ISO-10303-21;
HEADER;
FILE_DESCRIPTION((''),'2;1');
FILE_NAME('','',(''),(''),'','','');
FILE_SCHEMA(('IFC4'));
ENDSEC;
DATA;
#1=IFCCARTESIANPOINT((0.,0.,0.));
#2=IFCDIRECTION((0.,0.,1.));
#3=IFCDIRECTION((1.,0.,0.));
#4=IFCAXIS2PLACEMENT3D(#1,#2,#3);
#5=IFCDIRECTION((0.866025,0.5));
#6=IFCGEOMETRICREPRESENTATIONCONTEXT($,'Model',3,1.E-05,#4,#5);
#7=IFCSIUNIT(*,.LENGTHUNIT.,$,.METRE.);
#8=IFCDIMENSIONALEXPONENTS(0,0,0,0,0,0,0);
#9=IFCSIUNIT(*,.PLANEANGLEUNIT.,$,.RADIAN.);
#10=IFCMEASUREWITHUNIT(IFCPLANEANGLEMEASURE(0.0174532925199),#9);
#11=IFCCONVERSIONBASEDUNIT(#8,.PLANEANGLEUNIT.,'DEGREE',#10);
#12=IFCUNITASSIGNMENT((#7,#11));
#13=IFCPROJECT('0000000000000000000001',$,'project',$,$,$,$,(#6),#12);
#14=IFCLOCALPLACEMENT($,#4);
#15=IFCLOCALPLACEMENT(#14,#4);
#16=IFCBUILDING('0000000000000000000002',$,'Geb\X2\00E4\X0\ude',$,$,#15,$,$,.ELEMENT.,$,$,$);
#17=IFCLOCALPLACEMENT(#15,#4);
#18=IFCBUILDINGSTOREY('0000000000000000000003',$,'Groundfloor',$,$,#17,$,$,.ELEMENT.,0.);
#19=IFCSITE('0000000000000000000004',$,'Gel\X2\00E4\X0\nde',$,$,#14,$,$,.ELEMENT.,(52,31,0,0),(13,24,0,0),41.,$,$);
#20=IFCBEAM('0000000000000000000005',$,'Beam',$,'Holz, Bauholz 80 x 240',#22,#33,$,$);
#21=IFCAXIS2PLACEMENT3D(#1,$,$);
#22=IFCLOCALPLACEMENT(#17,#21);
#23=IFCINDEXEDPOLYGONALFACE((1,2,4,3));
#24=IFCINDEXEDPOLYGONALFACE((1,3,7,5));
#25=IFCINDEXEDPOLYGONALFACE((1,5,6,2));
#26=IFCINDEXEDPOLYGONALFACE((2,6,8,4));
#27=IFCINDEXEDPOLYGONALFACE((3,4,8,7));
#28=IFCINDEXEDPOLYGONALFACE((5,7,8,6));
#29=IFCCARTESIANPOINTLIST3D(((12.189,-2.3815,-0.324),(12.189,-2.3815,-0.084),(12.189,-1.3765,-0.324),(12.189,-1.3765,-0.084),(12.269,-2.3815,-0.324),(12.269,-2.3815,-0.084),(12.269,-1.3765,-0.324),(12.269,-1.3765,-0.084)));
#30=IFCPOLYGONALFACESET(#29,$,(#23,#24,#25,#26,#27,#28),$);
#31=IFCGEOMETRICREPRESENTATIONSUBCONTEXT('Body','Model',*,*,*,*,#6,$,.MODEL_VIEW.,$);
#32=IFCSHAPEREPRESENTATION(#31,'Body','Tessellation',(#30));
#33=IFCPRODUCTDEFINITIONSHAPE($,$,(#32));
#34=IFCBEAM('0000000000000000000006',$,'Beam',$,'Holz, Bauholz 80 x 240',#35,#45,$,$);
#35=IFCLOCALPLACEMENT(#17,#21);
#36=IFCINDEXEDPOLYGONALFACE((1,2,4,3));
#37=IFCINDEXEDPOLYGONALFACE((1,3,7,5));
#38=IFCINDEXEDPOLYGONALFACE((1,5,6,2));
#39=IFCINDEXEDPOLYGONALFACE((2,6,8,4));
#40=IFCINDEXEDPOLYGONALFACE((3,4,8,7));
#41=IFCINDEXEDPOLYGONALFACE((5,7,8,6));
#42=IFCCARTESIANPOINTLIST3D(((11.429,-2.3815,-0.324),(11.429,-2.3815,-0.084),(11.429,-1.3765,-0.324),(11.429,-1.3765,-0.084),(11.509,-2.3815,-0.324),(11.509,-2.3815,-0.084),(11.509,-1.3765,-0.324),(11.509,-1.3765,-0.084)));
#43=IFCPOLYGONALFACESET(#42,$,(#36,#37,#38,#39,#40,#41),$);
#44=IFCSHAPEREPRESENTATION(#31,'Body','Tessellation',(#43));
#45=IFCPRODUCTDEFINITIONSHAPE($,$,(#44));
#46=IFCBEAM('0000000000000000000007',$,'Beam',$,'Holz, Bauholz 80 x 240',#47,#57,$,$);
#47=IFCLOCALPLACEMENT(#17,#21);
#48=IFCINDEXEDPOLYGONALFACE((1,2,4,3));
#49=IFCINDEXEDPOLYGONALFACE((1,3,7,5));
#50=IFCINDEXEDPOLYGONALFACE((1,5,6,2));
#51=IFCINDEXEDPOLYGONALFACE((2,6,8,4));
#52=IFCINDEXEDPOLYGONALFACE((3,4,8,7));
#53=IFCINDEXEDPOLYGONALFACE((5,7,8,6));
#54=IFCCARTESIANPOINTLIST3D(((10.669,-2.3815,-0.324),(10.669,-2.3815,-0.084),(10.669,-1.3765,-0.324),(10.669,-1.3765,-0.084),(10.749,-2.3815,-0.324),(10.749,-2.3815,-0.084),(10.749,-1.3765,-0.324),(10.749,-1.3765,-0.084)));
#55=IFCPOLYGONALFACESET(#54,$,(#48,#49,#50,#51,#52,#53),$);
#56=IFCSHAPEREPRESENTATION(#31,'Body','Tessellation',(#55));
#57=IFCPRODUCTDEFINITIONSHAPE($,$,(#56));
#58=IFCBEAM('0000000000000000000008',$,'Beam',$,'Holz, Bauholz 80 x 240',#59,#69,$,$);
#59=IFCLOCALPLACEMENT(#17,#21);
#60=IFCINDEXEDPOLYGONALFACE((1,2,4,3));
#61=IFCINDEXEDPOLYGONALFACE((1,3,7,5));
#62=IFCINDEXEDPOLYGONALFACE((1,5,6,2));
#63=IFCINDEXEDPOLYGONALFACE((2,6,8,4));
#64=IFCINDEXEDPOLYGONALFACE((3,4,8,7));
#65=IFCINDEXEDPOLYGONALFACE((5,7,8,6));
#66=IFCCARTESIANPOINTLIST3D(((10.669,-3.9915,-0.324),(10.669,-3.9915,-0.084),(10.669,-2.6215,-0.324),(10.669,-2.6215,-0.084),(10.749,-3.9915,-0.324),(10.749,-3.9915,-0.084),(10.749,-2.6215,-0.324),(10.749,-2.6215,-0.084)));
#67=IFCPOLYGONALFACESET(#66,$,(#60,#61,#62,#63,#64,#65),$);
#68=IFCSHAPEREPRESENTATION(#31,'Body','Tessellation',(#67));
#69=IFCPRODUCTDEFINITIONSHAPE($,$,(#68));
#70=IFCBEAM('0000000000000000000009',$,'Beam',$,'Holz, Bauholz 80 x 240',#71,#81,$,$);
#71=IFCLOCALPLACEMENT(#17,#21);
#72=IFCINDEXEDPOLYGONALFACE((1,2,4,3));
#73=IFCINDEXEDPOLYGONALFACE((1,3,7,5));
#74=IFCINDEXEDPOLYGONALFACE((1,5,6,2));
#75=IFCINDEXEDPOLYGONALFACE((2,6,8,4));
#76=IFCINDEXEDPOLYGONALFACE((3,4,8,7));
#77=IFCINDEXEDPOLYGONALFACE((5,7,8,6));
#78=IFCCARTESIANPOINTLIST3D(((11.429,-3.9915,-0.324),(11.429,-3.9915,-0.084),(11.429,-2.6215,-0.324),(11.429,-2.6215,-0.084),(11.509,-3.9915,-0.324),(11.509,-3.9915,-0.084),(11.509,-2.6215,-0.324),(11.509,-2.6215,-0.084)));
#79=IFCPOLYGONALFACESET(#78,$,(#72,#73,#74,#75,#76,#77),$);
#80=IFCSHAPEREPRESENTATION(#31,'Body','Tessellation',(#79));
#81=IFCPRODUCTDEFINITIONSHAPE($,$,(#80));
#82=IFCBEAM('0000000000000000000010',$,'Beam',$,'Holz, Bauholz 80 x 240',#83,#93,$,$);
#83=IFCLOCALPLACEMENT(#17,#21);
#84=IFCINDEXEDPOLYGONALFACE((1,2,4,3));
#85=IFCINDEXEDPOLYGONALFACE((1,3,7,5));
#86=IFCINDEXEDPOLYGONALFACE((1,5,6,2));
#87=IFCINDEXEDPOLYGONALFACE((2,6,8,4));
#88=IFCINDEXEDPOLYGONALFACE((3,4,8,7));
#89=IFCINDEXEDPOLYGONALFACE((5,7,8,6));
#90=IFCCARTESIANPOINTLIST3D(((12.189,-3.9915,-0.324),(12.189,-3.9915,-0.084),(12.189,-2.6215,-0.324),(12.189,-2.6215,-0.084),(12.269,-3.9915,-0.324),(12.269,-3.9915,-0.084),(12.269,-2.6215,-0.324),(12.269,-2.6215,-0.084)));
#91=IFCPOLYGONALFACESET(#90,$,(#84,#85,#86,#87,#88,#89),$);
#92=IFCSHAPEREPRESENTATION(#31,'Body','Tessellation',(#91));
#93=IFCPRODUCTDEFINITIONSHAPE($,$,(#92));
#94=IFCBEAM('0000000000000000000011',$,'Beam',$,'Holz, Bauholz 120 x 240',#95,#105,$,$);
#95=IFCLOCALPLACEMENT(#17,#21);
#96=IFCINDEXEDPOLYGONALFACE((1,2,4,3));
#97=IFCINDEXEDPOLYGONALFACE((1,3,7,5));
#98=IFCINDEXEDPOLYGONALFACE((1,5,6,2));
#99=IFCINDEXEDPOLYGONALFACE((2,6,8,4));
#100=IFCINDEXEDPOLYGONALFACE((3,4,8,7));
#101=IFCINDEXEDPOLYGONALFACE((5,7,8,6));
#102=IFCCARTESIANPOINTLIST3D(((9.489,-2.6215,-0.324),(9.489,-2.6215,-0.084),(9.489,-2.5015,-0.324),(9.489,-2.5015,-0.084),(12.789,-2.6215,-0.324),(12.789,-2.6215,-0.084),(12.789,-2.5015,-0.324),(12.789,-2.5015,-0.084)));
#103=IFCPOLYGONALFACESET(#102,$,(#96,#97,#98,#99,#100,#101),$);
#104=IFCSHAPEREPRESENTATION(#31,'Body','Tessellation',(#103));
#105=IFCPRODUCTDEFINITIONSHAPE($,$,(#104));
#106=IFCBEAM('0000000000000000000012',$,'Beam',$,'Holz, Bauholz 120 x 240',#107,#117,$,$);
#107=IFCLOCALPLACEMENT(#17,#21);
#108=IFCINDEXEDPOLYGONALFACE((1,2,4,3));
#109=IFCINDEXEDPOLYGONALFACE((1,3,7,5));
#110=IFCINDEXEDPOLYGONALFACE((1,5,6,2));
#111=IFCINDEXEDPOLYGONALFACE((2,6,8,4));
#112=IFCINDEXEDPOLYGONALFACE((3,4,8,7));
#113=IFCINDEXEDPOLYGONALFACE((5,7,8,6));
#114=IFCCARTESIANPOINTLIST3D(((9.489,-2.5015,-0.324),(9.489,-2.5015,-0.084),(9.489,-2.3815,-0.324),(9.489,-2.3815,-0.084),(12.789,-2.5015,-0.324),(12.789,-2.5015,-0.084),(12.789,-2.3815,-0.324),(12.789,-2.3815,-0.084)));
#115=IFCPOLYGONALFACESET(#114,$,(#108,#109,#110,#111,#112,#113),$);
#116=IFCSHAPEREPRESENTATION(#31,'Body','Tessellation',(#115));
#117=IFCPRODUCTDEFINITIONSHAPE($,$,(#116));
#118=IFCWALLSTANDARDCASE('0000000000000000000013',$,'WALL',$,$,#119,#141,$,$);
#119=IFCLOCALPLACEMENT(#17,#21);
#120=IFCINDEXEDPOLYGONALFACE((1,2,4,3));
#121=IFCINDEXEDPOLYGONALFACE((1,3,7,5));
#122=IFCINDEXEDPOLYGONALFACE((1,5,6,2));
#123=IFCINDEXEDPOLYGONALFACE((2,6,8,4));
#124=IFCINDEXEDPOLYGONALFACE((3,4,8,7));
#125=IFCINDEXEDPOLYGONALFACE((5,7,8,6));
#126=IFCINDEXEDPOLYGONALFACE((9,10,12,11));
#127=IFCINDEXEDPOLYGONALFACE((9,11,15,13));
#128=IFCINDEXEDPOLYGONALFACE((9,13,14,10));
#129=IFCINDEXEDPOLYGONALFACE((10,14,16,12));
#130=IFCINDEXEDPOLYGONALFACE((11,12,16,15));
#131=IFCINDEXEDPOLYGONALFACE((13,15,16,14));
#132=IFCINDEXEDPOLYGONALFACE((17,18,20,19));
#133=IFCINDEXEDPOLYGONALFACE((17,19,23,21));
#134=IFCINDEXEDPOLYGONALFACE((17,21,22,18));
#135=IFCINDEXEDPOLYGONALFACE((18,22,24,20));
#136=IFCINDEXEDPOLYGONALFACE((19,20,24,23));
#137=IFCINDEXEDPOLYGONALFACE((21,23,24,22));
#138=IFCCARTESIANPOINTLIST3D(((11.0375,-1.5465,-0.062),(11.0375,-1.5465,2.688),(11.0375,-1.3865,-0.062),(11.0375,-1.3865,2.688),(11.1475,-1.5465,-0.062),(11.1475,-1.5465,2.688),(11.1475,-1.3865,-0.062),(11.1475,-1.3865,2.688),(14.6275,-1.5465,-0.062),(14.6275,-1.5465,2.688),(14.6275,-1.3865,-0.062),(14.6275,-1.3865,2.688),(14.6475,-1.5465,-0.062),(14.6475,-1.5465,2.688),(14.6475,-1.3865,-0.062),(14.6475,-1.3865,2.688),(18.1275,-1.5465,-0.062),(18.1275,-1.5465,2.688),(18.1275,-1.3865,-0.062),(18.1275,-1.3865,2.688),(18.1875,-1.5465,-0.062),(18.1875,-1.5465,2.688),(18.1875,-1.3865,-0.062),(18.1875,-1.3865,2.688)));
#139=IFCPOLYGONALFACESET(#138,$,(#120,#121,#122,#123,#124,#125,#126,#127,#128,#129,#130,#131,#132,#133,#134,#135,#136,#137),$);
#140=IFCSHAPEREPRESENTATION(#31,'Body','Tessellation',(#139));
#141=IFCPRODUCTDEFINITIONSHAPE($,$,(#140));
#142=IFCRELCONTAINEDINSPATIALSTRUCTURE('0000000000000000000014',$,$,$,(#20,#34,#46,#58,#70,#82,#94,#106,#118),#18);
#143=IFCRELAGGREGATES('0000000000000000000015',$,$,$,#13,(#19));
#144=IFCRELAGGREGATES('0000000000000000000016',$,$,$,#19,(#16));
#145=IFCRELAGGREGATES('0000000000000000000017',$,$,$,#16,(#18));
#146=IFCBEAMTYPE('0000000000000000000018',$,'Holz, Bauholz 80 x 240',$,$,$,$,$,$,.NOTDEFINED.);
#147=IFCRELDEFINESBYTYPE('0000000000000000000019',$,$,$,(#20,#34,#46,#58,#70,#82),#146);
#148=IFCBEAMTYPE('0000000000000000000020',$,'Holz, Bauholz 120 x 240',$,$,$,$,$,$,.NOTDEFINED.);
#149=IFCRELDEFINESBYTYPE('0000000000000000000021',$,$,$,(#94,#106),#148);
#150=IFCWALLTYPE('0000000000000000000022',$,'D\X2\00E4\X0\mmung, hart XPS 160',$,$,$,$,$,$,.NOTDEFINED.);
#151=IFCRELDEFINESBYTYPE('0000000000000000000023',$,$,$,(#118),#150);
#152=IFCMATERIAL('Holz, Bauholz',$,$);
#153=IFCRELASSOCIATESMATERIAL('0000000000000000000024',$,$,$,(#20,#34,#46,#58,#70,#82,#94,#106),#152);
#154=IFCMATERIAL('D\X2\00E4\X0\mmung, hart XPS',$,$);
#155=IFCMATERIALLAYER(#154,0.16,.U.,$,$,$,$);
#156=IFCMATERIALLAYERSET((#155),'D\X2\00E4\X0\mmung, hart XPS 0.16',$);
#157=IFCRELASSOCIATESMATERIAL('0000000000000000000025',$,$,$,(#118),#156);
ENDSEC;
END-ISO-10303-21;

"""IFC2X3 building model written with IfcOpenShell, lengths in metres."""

from ifc_helpers import new_model, entity, si_unit, converted_unit, direction, frame, frame_2d, origin_with_axes, origin_2d_with_axis, place, context, subcontext, project, spatial, polyline, rectangle, outline, extrude, material, layer, layer_set, layer_usage, type_object, element, save


model = new_model("IFC2X3")

# Units and contexts
model_context = context("Model", 3, precision=1e-05, world=origin_with_axes(), true_north=direction((0.866025, 0.5)))
body_context = subcontext(model_context, "Body", "Model", "MODEL_VIEW")
ifc_project = project(units=[si_unit("LENGTHUNIT", "METRE"), converted_unit("PLANEANGLEUNIT", "DEGREE", entity("IfcPlaneAngleMeasure", 0.0174532925199), si_unit("PLANEANGLEUNIT", "RADIAN"), dimensions=[0, 0, 0, 0, 0, 0, 0])], contexts=[model_context])

# Site, building, storey
site_placement = place(None, origin_with_axes())
site = spatial("IfcSite", under=ifc_project, at=site_placement, Name="Gelände", CompositionType="ELEMENT", RefLatitude=(52, 31, 0, 0), RefLongitude=(13, 24, 0, 0), RefElevation=41.0)
building_placement = place(site_placement, origin_with_axes())
building = spatial("IfcBuilding", under=site, at=building_placement, Name="Gebäude", CompositionType="ELEMENT")
storey_placement = place(building_placement, origin_with_axes())
storey = spatial("IfcBuildingStorey", under=building, at=storey_placement, Name="Groundfloor", CompositionType="ELEMENT", Elevation=0.0)

# Shared definitions
ifc_material_1 = material(Name="Holz, Bauholz")

# Beams
beam_type_1 = type_object("IfcBeamType", Name="Holz, Bauholz 80 x 240", PredefinedType="NOTDEFINED")
for number, where, z_axis, x_axis, name in (
    (1, (12.229, -2.3815, -0.084), (0.0, 0.0, 1.0), (1.0, 0.0, 0.0), "Beam"),
    (2, (11.469, -2.3815, -0.084), (0.0, 0.0, 1.0), (1.0, 0.0, 0.0), "Beam"),
    (3, (10.709, -2.3815, -0.084), (0.0, 0.0, 1.0), (1.0, 0.0, 0.0), "Beam"),
):
    element("IfcBeam", number, at=place(storey_placement, frame(where, z_axis=z_axis, x_axis=x_axis)), inside=storey, type_object=beam_type_1, material=ifc_material_1, Name=name, ObjectType="Holz, Bauholz 80 x 240", context=body_context, shape_type="SweptSolid", body=[
        extrude(rectangle(XDim=0.24, YDim=0.08, at=frame_2d((-0.12, 0.0), x_axis=(1.0, 0.0))), frame((0.0, 0.0, 0.0), z_axis=(0.0, 1.0, 0.0), x_axis=(0.0, 0.0, 1.0)), (0.0, 0.0, 1.0), 1.005),
    ])
for number, where, z_axis, x_axis, name in (
    (4, (10.709, -3.9915, -0.084), (0.0, 0.0, 1.0), (1.0, 0.0, 0.0), "Beam"),
    (5, (11.469, -3.9915, -0.084), (0.0, 0.0, 1.0), (1.0, 0.0, 0.0), "Beam"),
    (6, (12.229, -3.9915, -0.084), (0.0, 0.0, 1.0), (1.0, 0.0, 0.0), "Beam"),
):
    element("IfcBeam", number, at=place(storey_placement, frame(where, z_axis=z_axis, x_axis=x_axis)), inside=storey, type_object=beam_type_1, material=ifc_material_1, Name=name, ObjectType="Holz, Bauholz 80 x 240", context=body_context, shape_type="SweptSolid", body=[
        extrude(rectangle(XDim=0.24, YDim=0.08, at=frame_2d((-0.12, 0.0), x_axis=(1.0, 0.0))), frame((0.0, 0.0, 0.0), z_axis=(0.0, 1.0, 0.0), x_axis=(0.0, 0.0, 1.0)), (0.0, 0.0, 1.0), 1.37),
    ])
beam_type_2 = type_object("IfcBeamType", Name="Holz, Bauholz 120 x 240", PredefinedType="NOTDEFINED")
for number, where, z_axis, x_axis, name in (
    (7, (12.789, -2.5615, -0.084), (0.0, 0.0, 1.0), (0.0, 1.0, 0.0), "Beam"),
    (8, (12.789, -2.4415, -0.084), (0.0, 0.0, 1.0), (0.0, 1.0, 0.0), "Beam"),
):
    element("IfcBeam", number, at=place(storey_placement, frame(where, z_axis=z_axis, x_axis=x_axis)), inside=storey, type_object=beam_type_2, material=ifc_material_1, Name=name, ObjectType="Holz, Bauholz 120 x 240", context=body_context, shape_type="SweptSolid", body=[
        extrude(rectangle(XDim=0.24, YDim=0.12, at=frame_2d((-0.12, 0.0), x_axis=(1.0, 0.0))), frame((0.0, 0.0, 0.0), z_axis=(0.0, 1.0, 0.0), x_axis=(0.0, 0.0, 1.0)), (0.0, 0.0, 1.0), 3.3),
    ])

# Wall, openings
ifc_material_2 = material(Name="Dämmung, hart XPS")
ifc_layer_1 = layer(ifc_material_2, 0.16, ventilated="UNKNOWN")
ifc_layer_set_1 = layer_set([ifc_layer_1], Name="Dämmung, hart XPS 0.16")
ifc_layer_usage_1 = layer_usage(ifc_layer_set_1, "AXIS2", "NEGATIVE", 0.0)
wall_type_1 = type_object("IfcWallType", Name="Dämmung, hart XPS 160", PredefinedType="NOTDEFINED")
wall_1_placement = place(storey_placement, frame((11.0375, -1.3865, -0.062), z_axis=(0.0, 0.0, 1.0), x_axis=(1.0, 0.0, 0.0)))
wall_1 = element("IfcWallStandardCase", 9, at=wall_1_placement, inside=storey, type_object=wall_type_1, material=ifc_layer_usage_1, Name="WALL", context=body_context, shape_type="SweptSolid", body=[
    extrude(outline(polyline([(0.0, -0.16), (7.15, -0.16), (7.15, 0.0), (0.0, 0.0), (0.0, -0.16)])), origin_with_axes(), (0.0, 0.0, 1.0), 2.75),
])
opening_1_placement = place(wall_1_placement, frame((1.85, 0.0, 0.0), z_axis=(0.0, 0.0, 1.0), x_axis=(1.0, 0.0, 0.0)))
element("IfcOpeningElement", 10, at=opening_1_placement, cuts=wall_1, context=body_context, shape_type="SweptSolid", body=[
    extrude(rectangle(XDim=3.48, YDim=2.75, at=origin_2d_with_axis()), frame((0.0, -0.16, 1.375), z_axis=(0.0, -1.0, 0.0), x_axis=(1.0, 0.0, 0.0)), (0.0, 0.0, -1.0), 0.48),
])
opening_2_placement = place(wall_1_placement, frame((5.35, 0.0, 0.0), z_axis=(0.0, 0.0, 1.0), x_axis=(1.0, 0.0, 0.0)))
element("IfcOpeningElement", 11, at=opening_2_placement, cuts=wall_1, context=body_context, shape_type="SweptSolid", body=[
    extrude(rectangle(XDim=3.48, YDim=2.75, at=origin_2d_with_axis()), frame((0.0, -0.16, 1.375), z_axis=(0.0, -1.0, 0.0), x_axis=(1.0, 0.0, 0.0)), (0.0, 0.0, -1.0), 0.48),
])

save(model, "model.ifc")
